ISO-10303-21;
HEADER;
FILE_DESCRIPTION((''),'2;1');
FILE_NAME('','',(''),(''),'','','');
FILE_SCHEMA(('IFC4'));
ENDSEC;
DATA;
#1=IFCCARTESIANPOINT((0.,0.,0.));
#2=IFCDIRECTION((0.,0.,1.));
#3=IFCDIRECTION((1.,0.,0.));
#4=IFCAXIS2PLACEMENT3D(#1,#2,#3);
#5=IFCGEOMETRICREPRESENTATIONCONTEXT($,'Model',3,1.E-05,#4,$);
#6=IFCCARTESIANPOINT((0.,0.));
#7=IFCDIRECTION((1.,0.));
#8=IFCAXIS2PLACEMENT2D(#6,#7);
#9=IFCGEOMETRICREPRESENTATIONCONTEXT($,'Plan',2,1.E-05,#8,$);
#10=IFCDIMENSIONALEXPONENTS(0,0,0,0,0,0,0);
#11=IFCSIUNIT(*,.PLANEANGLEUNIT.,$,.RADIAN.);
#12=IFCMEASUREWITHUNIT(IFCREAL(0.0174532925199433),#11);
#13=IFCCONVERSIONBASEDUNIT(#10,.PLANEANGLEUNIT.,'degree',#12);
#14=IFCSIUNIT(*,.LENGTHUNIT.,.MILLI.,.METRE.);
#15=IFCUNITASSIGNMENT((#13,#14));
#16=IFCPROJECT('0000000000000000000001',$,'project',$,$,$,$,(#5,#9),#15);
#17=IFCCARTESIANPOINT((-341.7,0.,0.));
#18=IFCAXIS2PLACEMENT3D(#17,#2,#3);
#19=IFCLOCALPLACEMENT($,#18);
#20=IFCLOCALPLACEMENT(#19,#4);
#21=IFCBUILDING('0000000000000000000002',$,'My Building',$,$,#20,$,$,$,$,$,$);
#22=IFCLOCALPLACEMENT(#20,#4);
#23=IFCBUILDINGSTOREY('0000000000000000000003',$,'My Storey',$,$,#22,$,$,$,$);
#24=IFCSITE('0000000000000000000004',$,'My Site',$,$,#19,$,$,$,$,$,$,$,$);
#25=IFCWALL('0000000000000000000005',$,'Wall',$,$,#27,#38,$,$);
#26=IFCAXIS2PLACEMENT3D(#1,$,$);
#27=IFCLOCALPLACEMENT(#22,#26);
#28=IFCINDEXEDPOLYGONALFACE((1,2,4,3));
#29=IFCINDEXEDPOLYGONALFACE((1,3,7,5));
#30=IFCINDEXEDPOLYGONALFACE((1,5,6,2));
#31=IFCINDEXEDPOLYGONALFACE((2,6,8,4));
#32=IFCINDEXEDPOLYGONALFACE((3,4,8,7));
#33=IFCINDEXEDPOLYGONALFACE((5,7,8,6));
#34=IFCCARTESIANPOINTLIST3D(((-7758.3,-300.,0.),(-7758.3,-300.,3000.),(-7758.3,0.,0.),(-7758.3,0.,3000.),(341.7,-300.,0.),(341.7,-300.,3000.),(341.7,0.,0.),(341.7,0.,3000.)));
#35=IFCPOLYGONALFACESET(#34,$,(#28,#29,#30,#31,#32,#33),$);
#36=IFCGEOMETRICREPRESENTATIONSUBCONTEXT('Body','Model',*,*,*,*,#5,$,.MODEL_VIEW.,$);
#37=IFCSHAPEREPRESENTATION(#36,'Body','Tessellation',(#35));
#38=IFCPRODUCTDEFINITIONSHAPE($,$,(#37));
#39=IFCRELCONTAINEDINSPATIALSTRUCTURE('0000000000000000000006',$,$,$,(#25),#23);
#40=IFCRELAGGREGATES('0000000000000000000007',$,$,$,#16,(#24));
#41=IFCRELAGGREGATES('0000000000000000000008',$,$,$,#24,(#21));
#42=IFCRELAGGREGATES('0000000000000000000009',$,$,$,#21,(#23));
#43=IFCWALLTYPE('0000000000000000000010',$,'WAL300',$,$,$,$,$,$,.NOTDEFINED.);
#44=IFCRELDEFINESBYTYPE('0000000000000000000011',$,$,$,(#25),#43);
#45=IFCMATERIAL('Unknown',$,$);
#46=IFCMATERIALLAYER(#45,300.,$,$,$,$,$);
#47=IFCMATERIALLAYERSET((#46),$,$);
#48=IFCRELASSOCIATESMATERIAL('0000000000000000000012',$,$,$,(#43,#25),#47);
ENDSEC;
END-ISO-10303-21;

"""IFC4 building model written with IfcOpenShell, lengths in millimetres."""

from ifc_helpers import new_model, entity, si_unit, converted_unit, frame, origin_with_axes, origin_2d_with_axis, place, context, subcontext, project, spatial, indexed_curve, outline, extrude, material, layer, layer_set, layer_usage, type_object, element, save


model = new_model("IFC4")

# Units and contexts
model_context = context("Model", 3, precision=1e-05, world=origin_with_axes())
plan_context = context("Plan", 2, precision=1e-05, world=origin_2d_with_axis())
body_context_1 = subcontext(model_context, "Body", "Model", "MODEL_VIEW")
ifc_project = project(units=[converted_unit("PLANEANGLEUNIT", "degree", entity("IfcReal", 0.0174532925199433), si_unit("PLANEANGLEUNIT", "RADIAN"), dimensions=[0, 0, 0, 0, 0, 0, 0]), si_unit("LENGTHUNIT", "METRE", prefix="MILLI")], contexts=[model_context, plan_context])

# Site, building, storey
site_placement = place(None, frame((-341.7, 0.0, 0.0), z_axis=(0.0, 0.0, 1.0), x_axis=(1.0, 0.0, 0.0)))
site = spatial("IfcSite", under=ifc_project, at=site_placement, Name="My Site")
building_placement = place(site_placement, origin_with_axes())
building = spatial("IfcBuilding", under=site, at=building_placement, Name="My Building")
storey_placement = place(building_placement, origin_with_axes())
storey = spatial("IfcBuildingStorey", under=building, at=storey_placement, Name="My Storey")

# Shared definitions
ifc_material = material(Name="Unknown")

# Wall
ifc_layer_1 = layer(ifc_material, 300.0)
ifc_layer_set_1 = layer_set([ifc_layer_1])
ifc_layer_usage_1 = layer_usage(ifc_layer_set_1, "AXIS2", "POSITIVE", 0.0)
wall_type_1 = type_object("IfcWallType", Name="WAL300", PredefinedType="NOTDEFINED", material=ifc_layer_set_1)
wall_1_placement = place(storey_placement, frame((341.7, 0.0, 0.0), z_axis=(0.0, 0.0, 1.0), x_axis=(-1.0, 0.000001, 0.0)))
element("IfcWall", 1, at=wall_1_placement, inside=storey, type_object=wall_type_1, material=ifc_layer_usage_1, Name="Wall", context=body_context_1, shape_type="SweptSolid", body=[
    extrude(outline(indexed_curve([(0.0, 0.0), (0.0, 300.0), (8100.0, 300.0), (8100.0, 0.0), (0.0, 0.0)], self_intersect=False)), origin_with_axes(), (0.0, 0.0, 1.0), 3000.0),
])

save(model, "model.ifc")
